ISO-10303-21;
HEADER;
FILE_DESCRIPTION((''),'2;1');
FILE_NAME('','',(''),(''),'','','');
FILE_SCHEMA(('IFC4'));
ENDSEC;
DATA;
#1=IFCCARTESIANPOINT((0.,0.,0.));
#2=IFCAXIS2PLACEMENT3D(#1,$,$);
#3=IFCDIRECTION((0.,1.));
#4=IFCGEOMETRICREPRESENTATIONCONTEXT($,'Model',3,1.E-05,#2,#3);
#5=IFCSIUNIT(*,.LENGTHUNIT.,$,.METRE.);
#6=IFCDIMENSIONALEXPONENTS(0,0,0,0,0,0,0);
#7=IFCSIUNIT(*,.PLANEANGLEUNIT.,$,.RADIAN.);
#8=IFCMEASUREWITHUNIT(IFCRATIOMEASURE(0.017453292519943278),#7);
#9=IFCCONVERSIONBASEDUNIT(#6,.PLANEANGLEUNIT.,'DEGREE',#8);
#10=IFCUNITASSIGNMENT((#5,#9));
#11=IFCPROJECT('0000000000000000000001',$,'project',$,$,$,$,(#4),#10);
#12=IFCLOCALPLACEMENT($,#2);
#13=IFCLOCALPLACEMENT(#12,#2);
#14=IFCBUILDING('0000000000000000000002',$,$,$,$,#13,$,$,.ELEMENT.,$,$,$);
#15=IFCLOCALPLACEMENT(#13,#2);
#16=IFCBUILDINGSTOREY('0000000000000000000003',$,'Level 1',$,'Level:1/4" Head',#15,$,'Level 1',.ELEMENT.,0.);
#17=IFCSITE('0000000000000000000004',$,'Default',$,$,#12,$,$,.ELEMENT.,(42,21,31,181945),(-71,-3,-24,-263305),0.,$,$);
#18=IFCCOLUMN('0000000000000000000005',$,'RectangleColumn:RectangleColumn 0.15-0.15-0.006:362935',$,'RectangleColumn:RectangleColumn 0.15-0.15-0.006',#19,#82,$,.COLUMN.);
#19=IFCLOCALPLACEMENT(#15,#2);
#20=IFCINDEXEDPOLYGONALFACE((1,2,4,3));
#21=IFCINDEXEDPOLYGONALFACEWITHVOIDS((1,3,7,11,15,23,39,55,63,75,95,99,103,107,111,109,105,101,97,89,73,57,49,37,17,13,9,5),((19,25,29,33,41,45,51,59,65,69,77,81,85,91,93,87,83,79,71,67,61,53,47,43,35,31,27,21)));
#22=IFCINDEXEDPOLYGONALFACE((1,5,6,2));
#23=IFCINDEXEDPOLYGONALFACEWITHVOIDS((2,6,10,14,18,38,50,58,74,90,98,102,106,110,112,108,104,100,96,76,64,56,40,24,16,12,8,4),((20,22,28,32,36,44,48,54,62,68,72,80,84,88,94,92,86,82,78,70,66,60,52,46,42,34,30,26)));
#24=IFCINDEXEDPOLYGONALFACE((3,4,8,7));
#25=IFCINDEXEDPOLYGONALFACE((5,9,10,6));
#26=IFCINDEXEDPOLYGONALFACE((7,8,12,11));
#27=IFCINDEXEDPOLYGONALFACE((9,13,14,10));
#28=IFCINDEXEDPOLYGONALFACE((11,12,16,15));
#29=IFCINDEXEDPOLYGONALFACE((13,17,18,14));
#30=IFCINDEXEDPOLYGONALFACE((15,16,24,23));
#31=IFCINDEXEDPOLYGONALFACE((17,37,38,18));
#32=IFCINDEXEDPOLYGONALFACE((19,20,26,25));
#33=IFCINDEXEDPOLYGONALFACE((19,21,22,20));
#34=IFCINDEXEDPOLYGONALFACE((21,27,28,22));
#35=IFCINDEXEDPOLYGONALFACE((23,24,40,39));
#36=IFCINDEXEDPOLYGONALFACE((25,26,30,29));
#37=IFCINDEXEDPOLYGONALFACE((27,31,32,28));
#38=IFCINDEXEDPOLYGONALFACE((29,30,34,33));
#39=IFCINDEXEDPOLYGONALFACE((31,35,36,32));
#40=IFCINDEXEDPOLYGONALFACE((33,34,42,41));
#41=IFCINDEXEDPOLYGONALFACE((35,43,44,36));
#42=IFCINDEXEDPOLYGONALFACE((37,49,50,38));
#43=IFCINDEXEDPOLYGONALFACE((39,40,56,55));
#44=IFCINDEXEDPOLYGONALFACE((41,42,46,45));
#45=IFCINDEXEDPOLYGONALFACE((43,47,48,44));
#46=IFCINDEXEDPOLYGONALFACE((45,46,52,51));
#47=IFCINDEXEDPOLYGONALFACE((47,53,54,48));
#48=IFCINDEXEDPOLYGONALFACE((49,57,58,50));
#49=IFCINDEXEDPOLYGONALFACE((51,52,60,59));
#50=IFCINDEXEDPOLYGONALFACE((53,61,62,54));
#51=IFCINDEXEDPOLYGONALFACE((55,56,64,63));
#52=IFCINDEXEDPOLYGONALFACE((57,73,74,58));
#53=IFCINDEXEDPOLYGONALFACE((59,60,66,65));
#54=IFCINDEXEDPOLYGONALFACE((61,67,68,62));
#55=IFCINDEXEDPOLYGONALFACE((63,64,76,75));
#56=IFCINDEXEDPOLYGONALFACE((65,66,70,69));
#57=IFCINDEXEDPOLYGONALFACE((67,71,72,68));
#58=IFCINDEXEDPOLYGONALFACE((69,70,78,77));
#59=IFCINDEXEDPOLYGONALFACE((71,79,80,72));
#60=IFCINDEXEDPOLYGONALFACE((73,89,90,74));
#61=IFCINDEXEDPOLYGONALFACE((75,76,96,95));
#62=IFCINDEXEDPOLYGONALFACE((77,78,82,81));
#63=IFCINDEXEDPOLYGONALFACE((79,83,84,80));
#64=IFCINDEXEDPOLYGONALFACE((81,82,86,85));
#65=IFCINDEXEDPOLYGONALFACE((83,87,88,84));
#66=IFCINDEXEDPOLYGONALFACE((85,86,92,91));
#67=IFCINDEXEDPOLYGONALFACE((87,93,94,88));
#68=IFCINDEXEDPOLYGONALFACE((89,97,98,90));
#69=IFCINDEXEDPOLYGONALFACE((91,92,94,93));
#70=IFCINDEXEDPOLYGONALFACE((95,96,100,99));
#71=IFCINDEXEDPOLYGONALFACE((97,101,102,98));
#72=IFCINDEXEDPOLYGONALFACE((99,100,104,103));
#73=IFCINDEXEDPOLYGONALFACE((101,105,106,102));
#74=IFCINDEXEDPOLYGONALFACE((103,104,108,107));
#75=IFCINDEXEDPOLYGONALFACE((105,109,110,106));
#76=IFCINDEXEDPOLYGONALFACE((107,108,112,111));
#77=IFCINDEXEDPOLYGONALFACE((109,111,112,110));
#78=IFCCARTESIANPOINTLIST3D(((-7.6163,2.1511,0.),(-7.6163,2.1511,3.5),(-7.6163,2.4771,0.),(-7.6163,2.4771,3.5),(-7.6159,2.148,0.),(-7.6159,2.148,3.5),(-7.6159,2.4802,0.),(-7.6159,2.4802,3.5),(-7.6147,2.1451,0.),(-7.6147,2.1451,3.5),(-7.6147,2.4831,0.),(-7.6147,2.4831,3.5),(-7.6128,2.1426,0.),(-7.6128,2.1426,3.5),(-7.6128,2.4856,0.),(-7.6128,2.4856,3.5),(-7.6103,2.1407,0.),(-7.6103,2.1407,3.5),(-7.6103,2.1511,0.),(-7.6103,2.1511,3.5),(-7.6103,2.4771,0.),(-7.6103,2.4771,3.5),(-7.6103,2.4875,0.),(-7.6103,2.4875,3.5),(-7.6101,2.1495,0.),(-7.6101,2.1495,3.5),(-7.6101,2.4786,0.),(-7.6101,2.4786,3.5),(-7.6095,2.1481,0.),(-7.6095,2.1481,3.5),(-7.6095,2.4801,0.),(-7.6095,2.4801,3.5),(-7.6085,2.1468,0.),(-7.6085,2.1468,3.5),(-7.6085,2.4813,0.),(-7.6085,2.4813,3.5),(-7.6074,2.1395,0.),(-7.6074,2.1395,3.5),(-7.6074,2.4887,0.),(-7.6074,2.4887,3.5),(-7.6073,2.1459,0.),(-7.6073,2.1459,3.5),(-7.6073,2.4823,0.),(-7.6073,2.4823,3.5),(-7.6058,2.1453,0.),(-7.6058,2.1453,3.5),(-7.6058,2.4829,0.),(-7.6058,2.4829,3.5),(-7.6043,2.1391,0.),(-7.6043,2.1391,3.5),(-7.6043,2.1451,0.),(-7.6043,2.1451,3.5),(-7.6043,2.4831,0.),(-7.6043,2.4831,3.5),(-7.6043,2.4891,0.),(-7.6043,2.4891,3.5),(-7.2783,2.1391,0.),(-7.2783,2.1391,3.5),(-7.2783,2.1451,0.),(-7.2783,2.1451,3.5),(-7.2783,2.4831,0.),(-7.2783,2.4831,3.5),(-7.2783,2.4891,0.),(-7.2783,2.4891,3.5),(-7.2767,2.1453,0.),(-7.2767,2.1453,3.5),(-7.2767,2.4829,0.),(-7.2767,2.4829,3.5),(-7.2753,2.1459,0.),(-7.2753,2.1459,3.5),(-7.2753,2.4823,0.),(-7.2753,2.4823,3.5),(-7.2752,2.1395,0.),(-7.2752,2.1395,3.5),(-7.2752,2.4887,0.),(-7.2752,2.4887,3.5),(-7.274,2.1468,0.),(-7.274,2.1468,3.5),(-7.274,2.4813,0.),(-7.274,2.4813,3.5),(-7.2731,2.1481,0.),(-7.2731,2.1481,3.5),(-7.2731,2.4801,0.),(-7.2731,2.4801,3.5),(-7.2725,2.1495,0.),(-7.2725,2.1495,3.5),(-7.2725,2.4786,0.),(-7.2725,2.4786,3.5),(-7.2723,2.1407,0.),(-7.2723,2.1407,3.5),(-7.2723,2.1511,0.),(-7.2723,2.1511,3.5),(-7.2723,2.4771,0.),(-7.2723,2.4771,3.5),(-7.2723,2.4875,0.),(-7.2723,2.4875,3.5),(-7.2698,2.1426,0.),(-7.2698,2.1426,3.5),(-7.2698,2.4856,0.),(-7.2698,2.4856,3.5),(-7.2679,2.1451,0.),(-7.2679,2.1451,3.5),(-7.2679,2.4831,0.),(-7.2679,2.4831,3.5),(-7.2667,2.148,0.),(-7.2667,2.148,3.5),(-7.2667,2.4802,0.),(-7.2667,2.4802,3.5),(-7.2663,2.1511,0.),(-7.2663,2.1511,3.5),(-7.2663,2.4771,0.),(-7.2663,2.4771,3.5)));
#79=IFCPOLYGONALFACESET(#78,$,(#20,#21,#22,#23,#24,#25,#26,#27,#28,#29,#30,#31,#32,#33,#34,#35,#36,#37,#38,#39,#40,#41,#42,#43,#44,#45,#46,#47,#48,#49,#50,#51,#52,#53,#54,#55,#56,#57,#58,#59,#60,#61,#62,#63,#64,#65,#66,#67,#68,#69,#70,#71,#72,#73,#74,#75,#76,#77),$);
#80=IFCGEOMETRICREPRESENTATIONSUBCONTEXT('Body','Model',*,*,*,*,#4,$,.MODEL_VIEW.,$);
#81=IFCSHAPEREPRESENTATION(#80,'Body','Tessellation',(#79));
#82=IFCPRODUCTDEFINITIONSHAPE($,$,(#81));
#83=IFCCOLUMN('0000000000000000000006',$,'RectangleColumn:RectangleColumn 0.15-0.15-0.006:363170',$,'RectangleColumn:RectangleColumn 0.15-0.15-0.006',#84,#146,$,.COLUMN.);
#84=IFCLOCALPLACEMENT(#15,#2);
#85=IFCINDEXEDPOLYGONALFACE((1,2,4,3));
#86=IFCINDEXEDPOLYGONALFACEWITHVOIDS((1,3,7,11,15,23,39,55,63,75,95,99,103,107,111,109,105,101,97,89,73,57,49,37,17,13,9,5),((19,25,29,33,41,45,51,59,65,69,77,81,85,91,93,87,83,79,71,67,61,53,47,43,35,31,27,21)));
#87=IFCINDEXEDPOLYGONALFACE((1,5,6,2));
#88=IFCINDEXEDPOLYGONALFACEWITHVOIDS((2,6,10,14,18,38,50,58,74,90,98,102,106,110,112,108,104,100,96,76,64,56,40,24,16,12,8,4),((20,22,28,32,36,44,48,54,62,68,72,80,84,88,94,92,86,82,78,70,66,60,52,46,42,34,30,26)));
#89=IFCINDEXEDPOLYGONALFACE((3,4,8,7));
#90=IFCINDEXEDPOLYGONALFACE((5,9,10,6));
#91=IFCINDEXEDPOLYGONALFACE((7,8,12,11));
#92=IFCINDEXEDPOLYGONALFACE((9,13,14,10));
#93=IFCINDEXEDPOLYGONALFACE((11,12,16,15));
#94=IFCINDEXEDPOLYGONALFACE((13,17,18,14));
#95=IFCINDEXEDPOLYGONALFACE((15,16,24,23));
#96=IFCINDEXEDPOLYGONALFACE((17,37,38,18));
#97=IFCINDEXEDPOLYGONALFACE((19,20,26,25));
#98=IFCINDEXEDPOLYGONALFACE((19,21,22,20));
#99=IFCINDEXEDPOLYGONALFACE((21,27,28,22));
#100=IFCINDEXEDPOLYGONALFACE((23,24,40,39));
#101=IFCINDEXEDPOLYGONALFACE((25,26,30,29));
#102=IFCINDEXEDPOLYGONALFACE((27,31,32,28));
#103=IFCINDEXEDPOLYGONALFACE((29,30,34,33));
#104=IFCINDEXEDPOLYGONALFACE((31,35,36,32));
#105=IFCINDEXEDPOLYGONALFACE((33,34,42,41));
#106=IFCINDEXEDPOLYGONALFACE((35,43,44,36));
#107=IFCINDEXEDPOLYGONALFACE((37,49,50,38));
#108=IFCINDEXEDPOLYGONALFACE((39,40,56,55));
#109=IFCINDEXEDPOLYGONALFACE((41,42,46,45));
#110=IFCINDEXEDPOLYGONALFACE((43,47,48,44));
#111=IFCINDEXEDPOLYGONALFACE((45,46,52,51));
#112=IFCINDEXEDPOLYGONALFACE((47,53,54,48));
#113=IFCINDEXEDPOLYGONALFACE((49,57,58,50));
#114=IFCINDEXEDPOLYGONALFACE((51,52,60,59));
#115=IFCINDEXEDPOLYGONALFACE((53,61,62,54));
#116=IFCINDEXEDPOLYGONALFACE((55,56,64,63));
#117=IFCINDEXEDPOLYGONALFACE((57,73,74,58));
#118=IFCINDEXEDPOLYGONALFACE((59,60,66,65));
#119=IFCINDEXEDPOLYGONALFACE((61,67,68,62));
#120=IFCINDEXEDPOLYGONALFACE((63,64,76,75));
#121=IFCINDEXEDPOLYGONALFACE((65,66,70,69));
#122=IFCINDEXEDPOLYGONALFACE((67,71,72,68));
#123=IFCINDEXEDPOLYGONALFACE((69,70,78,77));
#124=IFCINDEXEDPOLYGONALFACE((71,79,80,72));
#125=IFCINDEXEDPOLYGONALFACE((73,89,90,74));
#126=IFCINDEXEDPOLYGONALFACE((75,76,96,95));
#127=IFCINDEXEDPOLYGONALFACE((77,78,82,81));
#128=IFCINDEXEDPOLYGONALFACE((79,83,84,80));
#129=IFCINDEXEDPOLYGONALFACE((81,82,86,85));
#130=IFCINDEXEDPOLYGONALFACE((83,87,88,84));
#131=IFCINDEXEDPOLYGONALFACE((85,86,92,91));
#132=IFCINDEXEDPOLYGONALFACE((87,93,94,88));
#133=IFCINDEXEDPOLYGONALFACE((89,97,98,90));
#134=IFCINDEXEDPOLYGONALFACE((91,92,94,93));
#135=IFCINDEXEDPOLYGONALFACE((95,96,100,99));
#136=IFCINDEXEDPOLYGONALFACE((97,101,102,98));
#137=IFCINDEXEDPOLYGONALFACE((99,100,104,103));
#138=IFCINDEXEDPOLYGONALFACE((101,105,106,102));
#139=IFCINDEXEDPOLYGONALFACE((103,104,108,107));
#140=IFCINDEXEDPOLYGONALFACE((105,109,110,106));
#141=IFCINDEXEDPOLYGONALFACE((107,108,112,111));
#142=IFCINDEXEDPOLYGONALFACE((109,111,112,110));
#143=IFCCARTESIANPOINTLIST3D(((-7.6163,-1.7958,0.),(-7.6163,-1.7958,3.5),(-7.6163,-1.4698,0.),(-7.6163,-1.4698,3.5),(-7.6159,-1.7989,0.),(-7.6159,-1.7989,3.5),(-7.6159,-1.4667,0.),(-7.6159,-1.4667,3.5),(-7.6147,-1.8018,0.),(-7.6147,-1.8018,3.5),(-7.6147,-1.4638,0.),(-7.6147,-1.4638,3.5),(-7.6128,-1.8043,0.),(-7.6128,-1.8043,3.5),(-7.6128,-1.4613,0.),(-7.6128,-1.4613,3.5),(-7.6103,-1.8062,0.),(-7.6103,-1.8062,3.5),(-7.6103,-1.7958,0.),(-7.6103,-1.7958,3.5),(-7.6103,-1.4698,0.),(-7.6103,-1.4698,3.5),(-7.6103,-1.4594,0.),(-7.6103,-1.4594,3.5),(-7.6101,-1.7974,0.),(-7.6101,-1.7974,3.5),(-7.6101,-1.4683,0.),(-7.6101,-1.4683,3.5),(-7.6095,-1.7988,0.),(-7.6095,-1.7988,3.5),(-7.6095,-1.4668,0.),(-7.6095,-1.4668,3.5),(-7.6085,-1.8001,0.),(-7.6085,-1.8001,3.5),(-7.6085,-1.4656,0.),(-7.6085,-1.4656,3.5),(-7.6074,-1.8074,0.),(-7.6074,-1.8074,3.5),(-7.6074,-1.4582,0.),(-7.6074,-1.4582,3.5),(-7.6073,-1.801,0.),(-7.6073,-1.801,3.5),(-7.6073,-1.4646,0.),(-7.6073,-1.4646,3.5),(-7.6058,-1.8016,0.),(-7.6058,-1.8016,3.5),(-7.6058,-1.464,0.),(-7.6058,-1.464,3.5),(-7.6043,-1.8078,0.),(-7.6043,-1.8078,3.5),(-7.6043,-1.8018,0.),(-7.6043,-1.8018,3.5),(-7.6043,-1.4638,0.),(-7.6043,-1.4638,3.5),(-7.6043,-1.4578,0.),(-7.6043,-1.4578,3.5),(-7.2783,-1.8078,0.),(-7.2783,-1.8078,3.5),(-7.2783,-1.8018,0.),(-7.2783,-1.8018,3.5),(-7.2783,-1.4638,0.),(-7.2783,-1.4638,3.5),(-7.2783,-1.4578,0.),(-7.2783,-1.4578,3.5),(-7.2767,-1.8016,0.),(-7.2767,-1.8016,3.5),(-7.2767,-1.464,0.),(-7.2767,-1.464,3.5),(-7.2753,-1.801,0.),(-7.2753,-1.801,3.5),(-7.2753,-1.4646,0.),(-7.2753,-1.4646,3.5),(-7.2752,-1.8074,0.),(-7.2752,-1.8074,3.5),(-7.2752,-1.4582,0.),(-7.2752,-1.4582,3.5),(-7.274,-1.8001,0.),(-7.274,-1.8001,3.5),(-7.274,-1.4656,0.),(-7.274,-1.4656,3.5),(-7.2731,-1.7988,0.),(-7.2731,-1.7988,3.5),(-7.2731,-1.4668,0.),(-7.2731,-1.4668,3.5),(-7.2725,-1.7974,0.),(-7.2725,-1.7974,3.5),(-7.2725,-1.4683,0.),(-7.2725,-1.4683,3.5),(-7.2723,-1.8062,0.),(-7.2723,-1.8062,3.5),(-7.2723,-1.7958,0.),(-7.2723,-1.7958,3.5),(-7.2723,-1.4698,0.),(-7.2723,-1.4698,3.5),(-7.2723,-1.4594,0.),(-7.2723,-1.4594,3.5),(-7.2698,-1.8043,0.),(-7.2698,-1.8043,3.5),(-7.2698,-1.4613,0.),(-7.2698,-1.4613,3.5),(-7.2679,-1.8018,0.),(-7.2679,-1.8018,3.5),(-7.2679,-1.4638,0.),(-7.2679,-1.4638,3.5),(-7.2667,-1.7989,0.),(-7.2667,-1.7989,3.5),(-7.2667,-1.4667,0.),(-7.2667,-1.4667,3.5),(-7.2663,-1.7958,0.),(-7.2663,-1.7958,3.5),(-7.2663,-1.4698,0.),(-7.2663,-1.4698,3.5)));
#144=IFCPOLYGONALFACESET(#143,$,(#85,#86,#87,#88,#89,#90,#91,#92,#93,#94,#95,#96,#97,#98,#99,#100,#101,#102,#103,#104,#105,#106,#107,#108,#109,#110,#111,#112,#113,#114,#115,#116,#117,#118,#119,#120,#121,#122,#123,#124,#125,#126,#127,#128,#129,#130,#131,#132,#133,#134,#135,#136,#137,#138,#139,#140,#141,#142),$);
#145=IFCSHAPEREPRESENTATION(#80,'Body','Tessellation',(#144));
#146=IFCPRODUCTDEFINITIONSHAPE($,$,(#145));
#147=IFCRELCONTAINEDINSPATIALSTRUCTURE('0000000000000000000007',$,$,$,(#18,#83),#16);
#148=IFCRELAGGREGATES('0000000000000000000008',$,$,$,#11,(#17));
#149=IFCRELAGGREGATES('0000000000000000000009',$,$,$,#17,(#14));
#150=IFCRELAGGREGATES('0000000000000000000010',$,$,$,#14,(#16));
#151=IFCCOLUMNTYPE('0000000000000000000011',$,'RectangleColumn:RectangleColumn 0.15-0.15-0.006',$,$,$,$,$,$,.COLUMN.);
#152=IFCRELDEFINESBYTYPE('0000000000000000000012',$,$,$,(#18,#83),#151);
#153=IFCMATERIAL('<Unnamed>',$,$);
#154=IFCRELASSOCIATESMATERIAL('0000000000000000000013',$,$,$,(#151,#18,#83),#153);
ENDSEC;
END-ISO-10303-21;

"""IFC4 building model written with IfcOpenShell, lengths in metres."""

from ifc_helpers import new_model, entity, si_unit, converted_unit, direction, frame, origin, place, context, subcontext, project, spatial, line, arc, indexed_curve, outline, extrude, source, transform, mapped, material, type_object, type_shapes, element, save


model = new_model("IFC4")

# Units and contexts
model_context = context("Model", 3, precision=1e-05, world=origin(), true_north=direction((0.0, 1.0)))
body_context = subcontext(model_context, "Body", "Model", "MODEL_VIEW")
ifc_project = project(units=[si_unit("LENGTHUNIT", "METRE"), converted_unit("PLANEANGLEUNIT", "DEGREE", entity("IfcRatioMeasure", 0.017453292519943278), si_unit("PLANEANGLEUNIT", "RADIAN"), dimensions=[0, 0, 0, 0, 0, 0, 0])], contexts=[model_context])

# Site, building, storey
site_placement = place(None, origin())
site = spatial("IfcSite", under=ifc_project, at=site_placement, Name="Default", CompositionType="ELEMENT", RefLatitude=(42, 21, 31, 181945), RefLongitude=(-71, -3, -24, -263305), RefElevation=0.0)
building_placement = place(site_placement, origin())
building = spatial("IfcBuilding", under=site, at=building_placement, CompositionType="ELEMENT")
storey_placement = place(building_placement, origin())
storey = spatial("IfcBuildingStorey", under=building, at=storey_placement, Name="Level 1", ObjectType="Level:1/4\" Head", LongName="Level 1", CompositionType="ELEMENT", Elevation=0.0)

# Columns
ifc_material_1 = material(Name="<Unnamed>")
column_type = type_object("IfcColumnType", Name="RectangleColumn:RectangleColumn 0.15-0.15-0.006", PredefinedType="COLUMN", material=ifc_material_1)
shared_shape = source(origin(), body_context, "Body", "SweptSolid", [
    extrude(outline(indexed_curve([(-0.163, -0.175), (0.163, -0.175), (0.1715, -0.1715), (0.175, -0.163), (0.175, 0.163), (0.1715, 0.1715), (0.163, 0.175), (-0.163, 0.175), (-0.1715, 0.1715), (-0.175, 0.163), (-0.175, -0.163), (-0.1715, -0.1715)], segments=[line(1, 2), arc(2, 3, 4), line(4, 5), arc(5, 6, 7), line(7, 8), arc(8, 9, 10), line(10, 11), arc(11, 12, 1)], self_intersect=False), holes=[indexed_curve([(-0.163, -0.169), (-0.1672, -0.1672), (-0.169, -0.163), (-0.169, 0.163), (-0.1672, 0.1672), (-0.163, 0.169), (0.163, 0.169), (0.1672, 0.1672), (0.169, 0.163), (0.169, -0.163), (0.1672, -0.1672), (0.163, -0.169)], segments=[arc(1, 2, 3), line(3, 4), arc(4, 5, 6), line(6, 7), arc(7, 8, 9), line(9, 10), arc(10, 11, 12), line(12, 1)], self_intersect=False)]), frame((0.0, 0.0, 0.0), z_axis=(0.0, 0.0, 1.0), x_axis=(-1.0, 0.0, 0.0)), (0.0, 0.0, 1.0), 3.5),
])
type_shapes(column_type, [shared_shape])
for number, where, name in (
    (1, (-7.4413, 2.3141, 0.0), "RectangleColumn:RectangleColumn 0.15-0.15-0.006:362935"),
    (2, (-7.4413, -1.6328, 0.0), "RectangleColumn:RectangleColumn 0.15-0.15-0.006:363170"),
):
    element("IfcColumn", number, at=place(storey_placement, frame(where)), inside=storey, type_object=column_type, material=ifc_material_1, Name=name, ObjectType="RectangleColumn:RectangleColumn 0.15-0.15-0.006", PredefinedType="COLUMN", context=body_context, shape_type="MappedRepresentation", body=[
        mapped(shared_shape, transform((0.0, 0.0, 0.0), scale=1.0)),
    ])

save(model, "model.ifc")
